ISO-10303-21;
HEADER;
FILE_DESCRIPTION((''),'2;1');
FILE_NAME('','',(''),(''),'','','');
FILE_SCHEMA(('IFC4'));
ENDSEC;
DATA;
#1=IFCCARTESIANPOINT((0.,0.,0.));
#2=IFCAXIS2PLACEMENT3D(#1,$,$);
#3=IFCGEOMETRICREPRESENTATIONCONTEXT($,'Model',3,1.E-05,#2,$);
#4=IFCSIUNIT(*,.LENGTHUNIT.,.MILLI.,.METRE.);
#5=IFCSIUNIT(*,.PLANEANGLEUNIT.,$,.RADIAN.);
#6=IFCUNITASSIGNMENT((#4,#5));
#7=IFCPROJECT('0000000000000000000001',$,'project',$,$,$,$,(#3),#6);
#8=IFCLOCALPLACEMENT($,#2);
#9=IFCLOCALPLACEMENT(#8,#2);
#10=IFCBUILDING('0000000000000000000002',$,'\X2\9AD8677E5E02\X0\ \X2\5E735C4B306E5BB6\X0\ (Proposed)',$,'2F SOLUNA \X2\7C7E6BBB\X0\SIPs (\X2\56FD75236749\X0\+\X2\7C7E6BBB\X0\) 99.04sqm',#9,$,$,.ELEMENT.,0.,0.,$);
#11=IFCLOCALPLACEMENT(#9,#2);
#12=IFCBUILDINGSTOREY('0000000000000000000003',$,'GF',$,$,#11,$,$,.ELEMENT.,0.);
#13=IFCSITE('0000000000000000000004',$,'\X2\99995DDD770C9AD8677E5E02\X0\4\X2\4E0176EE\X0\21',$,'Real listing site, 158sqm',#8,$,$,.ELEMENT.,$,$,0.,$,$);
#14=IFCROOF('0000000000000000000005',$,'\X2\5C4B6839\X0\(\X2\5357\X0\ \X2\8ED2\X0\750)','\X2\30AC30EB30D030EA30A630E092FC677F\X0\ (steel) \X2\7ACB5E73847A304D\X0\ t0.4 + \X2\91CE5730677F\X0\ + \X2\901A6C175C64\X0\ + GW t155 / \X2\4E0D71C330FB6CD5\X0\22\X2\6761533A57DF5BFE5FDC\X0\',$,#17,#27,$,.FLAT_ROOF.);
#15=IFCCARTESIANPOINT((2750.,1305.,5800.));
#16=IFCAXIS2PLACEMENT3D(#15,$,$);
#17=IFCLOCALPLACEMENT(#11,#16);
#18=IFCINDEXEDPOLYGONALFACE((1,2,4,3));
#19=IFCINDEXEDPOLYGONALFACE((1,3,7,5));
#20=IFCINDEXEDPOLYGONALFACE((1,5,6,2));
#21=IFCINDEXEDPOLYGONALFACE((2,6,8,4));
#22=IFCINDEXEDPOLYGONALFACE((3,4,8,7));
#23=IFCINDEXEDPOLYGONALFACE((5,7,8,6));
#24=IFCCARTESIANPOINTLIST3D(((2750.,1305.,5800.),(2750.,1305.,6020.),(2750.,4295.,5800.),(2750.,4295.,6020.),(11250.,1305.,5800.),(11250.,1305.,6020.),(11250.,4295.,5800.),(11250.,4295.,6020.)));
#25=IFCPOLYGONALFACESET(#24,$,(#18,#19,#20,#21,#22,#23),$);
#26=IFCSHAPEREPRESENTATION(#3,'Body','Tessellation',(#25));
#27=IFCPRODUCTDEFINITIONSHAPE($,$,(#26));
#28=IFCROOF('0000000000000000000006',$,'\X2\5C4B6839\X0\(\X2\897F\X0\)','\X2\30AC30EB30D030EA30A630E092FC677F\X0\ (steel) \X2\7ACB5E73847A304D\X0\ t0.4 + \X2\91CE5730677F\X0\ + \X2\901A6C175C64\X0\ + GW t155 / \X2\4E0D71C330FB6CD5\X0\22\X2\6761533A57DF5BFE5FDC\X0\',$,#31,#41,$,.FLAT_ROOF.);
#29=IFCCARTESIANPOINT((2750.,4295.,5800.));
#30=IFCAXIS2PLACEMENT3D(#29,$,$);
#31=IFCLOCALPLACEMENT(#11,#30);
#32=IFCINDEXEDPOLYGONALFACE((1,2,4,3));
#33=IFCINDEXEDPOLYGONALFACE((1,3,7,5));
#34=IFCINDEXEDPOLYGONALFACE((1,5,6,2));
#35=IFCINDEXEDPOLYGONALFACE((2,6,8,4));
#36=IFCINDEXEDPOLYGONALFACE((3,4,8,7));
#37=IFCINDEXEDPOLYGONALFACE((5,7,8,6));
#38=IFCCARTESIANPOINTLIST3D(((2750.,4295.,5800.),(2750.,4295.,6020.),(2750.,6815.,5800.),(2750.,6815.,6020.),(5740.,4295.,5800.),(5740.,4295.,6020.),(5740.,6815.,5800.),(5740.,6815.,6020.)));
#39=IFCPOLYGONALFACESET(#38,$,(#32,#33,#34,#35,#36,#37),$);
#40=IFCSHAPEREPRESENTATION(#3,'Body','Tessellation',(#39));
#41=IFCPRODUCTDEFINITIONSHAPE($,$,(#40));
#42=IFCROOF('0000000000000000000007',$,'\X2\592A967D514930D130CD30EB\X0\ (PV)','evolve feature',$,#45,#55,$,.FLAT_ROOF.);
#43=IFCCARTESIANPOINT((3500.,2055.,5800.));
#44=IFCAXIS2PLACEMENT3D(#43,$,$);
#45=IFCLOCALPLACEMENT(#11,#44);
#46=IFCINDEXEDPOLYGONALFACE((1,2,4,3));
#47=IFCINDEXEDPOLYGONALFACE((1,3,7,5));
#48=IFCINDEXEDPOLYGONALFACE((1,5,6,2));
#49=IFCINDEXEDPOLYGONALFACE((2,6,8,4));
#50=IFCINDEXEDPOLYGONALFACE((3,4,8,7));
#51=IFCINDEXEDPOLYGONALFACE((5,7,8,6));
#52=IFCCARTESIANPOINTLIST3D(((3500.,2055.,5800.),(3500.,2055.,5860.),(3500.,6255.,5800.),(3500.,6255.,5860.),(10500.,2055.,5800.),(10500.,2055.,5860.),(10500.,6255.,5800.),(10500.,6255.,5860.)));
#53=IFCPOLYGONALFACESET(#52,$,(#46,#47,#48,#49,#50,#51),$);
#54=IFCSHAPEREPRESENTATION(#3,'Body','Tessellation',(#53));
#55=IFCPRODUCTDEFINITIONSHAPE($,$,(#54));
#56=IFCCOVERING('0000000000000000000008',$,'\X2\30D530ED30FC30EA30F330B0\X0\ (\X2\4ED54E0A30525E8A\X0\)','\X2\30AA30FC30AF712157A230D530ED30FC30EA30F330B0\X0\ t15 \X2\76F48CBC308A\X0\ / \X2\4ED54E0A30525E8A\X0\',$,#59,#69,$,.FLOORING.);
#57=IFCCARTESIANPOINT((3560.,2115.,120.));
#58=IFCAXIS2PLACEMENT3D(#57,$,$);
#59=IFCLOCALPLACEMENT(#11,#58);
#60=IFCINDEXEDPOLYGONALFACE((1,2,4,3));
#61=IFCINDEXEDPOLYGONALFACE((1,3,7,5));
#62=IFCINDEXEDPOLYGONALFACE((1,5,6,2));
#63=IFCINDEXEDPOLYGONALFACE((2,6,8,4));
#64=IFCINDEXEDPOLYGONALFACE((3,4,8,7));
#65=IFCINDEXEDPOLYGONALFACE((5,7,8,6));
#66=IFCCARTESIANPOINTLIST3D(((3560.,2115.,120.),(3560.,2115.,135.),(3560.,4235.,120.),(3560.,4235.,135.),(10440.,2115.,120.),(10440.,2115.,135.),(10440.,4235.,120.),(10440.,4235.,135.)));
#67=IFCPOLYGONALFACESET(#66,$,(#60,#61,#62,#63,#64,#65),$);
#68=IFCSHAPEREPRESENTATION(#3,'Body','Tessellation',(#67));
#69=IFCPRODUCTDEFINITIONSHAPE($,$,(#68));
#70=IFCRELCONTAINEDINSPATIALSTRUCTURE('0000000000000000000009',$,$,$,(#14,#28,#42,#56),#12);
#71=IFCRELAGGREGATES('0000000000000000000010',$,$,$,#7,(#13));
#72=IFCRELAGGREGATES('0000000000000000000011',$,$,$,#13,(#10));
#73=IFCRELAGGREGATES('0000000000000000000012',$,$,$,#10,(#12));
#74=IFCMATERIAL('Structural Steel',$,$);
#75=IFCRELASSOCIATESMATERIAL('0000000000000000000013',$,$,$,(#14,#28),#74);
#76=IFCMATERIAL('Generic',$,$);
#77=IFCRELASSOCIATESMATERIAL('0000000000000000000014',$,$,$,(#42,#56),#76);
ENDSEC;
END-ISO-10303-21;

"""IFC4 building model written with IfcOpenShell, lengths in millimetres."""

from ifc_helpers import new_model, si_unit, frame, frame_2d, origin, place, context, project, spatial, rectangle, extrude, material, element, save


model = new_model("IFC4")

# Units and contexts
model_context = context("Model", 3, precision=1e-05, world=origin())
ifc_project = project(units=[si_unit("LENGTHUNIT", "METRE", prefix="MILLI"), si_unit("PLANEANGLEUNIT", "RADIAN")], contexts=[model_context])

# Site, building, storey
site_placement = place(None, origin())
site = spatial("IfcSite", under=ifc_project, at=site_placement, Name="香川県高松市4丁目21", ObjectType="Real listing site, 158sqm", CompositionType="ELEMENT", RefElevation=0.0)
building_placement = place(site_placement, origin())
building = spatial("IfcBuilding", under=site, at=building_placement, Name="高松市 平屋の家 (Proposed)", ObjectType="2F SOLUNA 籾殻SIPs (国産杉+籾殻) 99.04sqm", CompositionType="ELEMENT", ElevationOfRefHeight=0.0, ElevationOfTerrain=0.0)
storey_placement = place(building_placement, origin())
storey = spatial("IfcBuildingStorey", under=building, at=storey_placement, Name="GF", CompositionType="ELEMENT", Elevation=0.0)

# Shared definitions
ifc_material_1 = material(Name="Generic")

# Roofs
ifc_material_2 = material(Name="Structural Steel")
roof_1_placement = place(storey_placement, frame((2750.0, 1305.0, 5800.0)))
element("IfcRoof", 1, at=roof_1_placement, inside=storey, material=ifc_material_2, Name="屋根(南 軒750)", Description="ガルバリウム鋼板 (steel) 立平葺き t0.4 + 野地板 + 通気層 + GW t155 / 不燃・法22条区域対応", PredefinedType="FLAT_ROOF", context=model_context, shape_type="SweptSolid", body=[
    extrude(rectangle(XDim=8500.0, YDim=2990.0, at=frame_2d((4250.0, 1495.0))), frame((2750.0, 1305.0, 5800.0)), (0.0, 0.0, 1.0), 220.0),
])
roof_2_placement = place(storey_placement, frame((2750.0, 4295.0, 5800.0)))
element("IfcRoof", 2, at=roof_2_placement, inside=storey, material=ifc_material_2, Name="屋根(西)", Description="ガルバリウム鋼板 (steel) 立平葺き t0.4 + 野地板 + 通気層 + GW t155 / 不燃・法22条区域対応", PredefinedType="FLAT_ROOF", context=model_context, shape_type="SweptSolid", body=[
    extrude(rectangle(XDim=2990.0, YDim=2520.0, at=frame_2d((1495.0, 1260.0))), frame((2750.0, 4295.0, 5800.0)), (0.0, 0.0, 1.0), 220.0),
])
roof_3_placement = place(storey_placement, frame((3500.0, 2055.0, 5800.0)))
element("IfcRoof", 3, at=roof_3_placement, inside=storey, material=ifc_material_1, Name="太陽光パネル (PV)", Description="evolve feature", PredefinedType="FLAT_ROOF", context=model_context, shape_type="SweptSolid", body=[
    extrude(rectangle(XDim=7000.0, YDim=4200.0, at=frame_2d((3500.0, 2100.0))), frame((3500.0, 2055.0, 5800.0)), (0.0, 0.0, 1.0), 60.0),
])

# Covering
covering_placement = place(storey_placement, frame((3560.0, 2115.0, 120.0)))
element("IfcCovering", 4, at=covering_placement, inside=storey, material=ifc_material_1, Name="フローリング (仕上げ床)", Description="オーク無垢フローリング t15 直貼り / 仕上げ床", PredefinedType="FLOORING", context=model_context, shape_type="SweptSolid", body=[
    extrude(rectangle(XDim=6880.0, YDim=2120.0, at=frame_2d((3440.0, 1060.0))), frame((3560.0, 2115.0, 120.0)), (0.0, 0.0, 1.0), 15.0),
])

save(model, "model.ifc")
